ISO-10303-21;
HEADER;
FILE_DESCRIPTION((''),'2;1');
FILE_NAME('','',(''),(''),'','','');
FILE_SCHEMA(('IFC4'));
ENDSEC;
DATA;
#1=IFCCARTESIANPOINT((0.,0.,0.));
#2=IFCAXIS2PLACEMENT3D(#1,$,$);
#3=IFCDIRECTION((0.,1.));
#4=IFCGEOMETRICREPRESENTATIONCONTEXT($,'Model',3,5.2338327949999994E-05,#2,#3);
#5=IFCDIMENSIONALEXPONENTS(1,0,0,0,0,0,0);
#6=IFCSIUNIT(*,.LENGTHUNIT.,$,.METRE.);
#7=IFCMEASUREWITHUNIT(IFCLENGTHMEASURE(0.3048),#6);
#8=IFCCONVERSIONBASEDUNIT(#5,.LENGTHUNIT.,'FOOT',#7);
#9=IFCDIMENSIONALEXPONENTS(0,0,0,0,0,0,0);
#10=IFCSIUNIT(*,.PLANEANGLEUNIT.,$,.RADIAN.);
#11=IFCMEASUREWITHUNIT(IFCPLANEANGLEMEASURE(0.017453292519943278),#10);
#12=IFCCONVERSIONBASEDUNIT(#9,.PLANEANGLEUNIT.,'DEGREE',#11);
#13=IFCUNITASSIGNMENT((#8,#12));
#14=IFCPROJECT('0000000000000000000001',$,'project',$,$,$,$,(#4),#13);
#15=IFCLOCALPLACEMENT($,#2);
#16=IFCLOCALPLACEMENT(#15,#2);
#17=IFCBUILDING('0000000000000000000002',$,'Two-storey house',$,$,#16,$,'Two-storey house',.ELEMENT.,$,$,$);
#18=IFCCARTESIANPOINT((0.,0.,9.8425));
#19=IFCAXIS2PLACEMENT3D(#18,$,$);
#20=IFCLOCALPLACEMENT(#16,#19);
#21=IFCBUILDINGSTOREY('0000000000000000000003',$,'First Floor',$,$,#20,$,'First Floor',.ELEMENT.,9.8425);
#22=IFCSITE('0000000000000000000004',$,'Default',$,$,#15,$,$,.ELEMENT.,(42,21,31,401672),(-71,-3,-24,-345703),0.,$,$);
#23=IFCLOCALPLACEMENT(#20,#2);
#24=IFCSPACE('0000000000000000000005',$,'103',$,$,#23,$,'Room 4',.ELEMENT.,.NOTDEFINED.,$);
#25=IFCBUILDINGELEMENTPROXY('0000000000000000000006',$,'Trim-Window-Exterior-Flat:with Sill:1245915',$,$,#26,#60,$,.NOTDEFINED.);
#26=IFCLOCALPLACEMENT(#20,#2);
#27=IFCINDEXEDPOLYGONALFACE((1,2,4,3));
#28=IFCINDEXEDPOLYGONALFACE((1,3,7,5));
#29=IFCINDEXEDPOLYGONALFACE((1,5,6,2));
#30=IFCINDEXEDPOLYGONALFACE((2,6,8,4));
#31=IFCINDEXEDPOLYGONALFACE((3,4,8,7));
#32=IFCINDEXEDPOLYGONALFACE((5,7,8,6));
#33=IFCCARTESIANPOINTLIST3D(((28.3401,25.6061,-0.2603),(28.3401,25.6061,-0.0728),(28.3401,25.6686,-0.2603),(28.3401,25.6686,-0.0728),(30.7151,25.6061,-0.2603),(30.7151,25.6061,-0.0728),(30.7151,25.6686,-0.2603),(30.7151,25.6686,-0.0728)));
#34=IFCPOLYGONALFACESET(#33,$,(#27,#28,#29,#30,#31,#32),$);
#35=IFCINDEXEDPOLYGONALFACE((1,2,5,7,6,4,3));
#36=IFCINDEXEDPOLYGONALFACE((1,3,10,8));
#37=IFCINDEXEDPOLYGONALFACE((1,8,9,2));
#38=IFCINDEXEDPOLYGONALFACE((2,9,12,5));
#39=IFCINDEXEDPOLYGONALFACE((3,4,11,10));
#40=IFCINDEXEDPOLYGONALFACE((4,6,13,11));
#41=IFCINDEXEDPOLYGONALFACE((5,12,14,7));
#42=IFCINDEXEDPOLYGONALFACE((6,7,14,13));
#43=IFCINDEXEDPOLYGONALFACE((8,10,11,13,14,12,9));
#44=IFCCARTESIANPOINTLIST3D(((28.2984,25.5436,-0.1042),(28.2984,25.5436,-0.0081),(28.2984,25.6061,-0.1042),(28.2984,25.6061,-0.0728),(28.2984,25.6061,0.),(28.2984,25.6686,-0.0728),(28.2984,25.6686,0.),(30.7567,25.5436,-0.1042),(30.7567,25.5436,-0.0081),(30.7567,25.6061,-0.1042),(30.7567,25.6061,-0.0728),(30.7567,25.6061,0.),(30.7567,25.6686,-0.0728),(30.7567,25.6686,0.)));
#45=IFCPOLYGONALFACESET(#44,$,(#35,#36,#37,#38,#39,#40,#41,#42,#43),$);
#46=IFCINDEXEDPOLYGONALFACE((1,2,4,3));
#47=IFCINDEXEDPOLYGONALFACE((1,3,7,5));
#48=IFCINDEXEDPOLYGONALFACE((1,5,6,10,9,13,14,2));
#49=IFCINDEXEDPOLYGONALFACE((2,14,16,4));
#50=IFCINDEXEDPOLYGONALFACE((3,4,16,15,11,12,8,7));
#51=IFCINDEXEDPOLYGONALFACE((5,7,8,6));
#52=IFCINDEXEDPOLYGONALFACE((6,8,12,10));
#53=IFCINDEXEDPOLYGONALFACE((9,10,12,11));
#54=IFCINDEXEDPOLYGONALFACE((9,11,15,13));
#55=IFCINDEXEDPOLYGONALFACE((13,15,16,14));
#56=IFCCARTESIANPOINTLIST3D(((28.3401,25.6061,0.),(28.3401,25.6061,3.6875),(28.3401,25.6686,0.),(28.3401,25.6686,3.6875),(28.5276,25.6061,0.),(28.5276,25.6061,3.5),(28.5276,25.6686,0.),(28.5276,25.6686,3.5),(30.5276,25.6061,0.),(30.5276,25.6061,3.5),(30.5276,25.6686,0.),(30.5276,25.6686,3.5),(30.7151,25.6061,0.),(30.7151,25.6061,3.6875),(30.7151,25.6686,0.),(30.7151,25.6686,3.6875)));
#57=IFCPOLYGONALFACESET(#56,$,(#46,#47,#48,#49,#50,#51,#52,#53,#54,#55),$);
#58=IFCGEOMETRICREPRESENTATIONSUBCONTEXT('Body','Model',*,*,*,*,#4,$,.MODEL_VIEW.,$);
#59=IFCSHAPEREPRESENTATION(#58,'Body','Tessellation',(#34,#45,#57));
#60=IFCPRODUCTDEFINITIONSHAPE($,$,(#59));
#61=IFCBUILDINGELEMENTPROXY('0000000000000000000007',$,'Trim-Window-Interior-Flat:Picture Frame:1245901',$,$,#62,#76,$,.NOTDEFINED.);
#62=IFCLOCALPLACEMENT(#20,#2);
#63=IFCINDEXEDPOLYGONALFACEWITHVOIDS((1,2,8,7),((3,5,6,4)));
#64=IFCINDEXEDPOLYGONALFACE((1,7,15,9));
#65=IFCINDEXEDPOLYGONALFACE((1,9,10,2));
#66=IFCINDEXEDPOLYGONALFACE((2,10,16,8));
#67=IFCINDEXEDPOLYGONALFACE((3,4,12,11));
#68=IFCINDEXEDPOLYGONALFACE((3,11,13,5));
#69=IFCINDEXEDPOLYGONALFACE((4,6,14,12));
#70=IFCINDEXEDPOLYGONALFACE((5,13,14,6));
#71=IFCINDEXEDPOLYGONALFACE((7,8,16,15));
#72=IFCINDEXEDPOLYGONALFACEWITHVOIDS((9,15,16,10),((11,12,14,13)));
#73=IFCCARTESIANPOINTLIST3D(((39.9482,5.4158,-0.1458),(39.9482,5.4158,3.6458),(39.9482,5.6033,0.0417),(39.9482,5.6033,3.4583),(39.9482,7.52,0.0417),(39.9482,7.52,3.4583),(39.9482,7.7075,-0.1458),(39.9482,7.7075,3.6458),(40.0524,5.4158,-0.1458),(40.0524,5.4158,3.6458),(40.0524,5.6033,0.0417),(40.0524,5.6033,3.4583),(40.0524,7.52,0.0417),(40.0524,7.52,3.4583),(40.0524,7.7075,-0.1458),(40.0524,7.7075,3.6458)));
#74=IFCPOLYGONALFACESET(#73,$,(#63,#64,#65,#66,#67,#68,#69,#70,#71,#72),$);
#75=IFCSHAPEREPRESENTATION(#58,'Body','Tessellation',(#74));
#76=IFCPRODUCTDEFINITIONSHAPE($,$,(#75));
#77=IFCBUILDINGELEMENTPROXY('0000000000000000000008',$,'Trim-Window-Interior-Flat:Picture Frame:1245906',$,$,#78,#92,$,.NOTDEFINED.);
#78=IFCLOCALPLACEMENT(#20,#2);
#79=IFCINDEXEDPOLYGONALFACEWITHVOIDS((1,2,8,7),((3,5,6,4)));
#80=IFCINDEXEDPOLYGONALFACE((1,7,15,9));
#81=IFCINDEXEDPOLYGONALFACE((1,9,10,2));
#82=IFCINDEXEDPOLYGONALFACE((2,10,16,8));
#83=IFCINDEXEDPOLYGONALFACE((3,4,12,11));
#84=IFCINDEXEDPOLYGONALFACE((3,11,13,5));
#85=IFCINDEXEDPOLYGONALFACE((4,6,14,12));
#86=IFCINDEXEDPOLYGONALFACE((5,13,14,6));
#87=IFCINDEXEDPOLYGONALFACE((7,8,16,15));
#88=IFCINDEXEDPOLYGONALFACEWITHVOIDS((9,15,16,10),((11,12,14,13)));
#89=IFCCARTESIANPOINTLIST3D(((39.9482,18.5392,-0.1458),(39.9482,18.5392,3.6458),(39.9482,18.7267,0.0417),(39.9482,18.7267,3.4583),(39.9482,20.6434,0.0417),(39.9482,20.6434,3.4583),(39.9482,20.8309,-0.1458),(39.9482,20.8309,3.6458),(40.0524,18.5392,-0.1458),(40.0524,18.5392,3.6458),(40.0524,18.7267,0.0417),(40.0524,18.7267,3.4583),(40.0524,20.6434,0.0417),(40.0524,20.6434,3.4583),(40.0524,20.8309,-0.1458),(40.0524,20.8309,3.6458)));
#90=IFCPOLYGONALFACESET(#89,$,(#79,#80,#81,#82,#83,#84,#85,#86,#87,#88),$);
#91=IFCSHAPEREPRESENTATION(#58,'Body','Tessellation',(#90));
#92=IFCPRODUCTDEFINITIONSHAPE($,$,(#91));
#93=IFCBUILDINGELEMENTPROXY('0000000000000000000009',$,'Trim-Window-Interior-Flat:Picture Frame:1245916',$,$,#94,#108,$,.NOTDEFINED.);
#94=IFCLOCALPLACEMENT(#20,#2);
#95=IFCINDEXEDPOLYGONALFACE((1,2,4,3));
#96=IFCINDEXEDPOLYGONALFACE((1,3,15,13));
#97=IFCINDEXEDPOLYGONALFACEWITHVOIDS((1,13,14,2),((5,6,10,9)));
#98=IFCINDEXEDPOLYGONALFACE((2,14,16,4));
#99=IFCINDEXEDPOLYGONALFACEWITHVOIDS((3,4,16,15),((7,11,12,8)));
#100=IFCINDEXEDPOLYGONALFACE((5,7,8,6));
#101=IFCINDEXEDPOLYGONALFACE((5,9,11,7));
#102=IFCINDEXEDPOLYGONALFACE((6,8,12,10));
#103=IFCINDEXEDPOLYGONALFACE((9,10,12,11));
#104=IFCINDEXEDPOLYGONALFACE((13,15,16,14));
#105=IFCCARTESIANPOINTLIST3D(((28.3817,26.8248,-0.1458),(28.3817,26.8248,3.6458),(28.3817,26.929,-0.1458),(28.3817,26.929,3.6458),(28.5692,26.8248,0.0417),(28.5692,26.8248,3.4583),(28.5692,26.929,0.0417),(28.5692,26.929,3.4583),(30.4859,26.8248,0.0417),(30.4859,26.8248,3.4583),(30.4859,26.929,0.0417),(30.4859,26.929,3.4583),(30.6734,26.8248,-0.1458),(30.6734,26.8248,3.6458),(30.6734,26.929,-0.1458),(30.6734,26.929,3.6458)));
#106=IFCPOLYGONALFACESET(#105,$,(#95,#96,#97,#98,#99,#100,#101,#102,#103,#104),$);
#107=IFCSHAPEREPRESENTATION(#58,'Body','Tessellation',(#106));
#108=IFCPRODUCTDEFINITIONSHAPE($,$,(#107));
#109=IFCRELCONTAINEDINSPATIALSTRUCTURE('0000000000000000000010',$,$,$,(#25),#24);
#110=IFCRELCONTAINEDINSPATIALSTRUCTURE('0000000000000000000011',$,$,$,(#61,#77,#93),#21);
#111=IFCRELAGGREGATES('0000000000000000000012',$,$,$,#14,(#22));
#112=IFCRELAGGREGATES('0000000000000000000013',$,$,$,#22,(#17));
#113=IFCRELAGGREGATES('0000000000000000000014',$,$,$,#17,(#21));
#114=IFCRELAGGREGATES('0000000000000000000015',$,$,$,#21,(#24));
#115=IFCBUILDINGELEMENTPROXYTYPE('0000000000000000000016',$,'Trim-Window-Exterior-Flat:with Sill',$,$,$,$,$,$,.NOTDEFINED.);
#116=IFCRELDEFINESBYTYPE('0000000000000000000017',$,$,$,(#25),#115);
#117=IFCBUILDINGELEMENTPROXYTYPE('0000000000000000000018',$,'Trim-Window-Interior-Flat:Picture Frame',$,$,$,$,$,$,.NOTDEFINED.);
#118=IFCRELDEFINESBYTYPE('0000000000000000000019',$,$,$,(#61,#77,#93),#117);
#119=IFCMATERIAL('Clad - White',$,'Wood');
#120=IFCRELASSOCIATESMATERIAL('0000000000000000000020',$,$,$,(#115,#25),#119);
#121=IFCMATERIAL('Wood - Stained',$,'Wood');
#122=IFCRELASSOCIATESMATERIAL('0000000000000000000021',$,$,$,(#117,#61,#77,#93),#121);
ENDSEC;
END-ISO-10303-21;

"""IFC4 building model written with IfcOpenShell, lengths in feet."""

from ifc_helpers import new_model, entity, si_unit, converted_unit, direction, frame, origin, place, context, subcontext, project, spatial, indexed_curve, outline, extrude, source, transform, mapped, material, type_object, type_shapes, element, save


model = new_model("IFC4")

# Units and contexts
model_context = context("Model", 3, precision=5.2338327949999994e-05, world=origin(), true_north=direction((0.0, 1.0)))
body_context = subcontext(model_context, "Body", "Model", "MODEL_VIEW")
ifc_project = project(units=[converted_unit("LENGTHUNIT", "FOOT", entity("IfcLengthMeasure", 0.3048), si_unit("LENGTHUNIT", "METRE"), dimensions=[1, 0, 0, 0, 0, 0, 0]), converted_unit("PLANEANGLEUNIT", "DEGREE", entity("IfcPlaneAngleMeasure", 0.017453292519943278), si_unit("PLANEANGLEUNIT", "RADIAN"), dimensions=[0, 0, 0, 0, 0, 0, 0])], contexts=[model_context])

# Site, building, storey
site_placement = place(None, origin())
site = spatial("IfcSite", under=ifc_project, at=site_placement, Name="Default", CompositionType="ELEMENT", RefLatitude=(42, 21, 31, 401672), RefLongitude=(-71, -3, -24, -345703), RefElevation=0.0)
building_placement = place(site_placement, origin())
building = spatial("IfcBuilding", under=site, at=building_placement, Name="Two-storey house", LongName="Two-storey house", CompositionType="ELEMENT")
storey_placement = place(building_placement, frame((0.0, 0.0, 9.8425)))
storey = spatial("IfcBuildingStorey", under=building, at=storey_placement, Name="First Floor", LongName="First Floor", CompositionType="ELEMENT", Elevation=9.8425)

# Shared definitions
ifc_material_1 = material(Name="Wood - Stained", Category="Wood")

# Shared definitions
ifc_material_2 = material(Name="Clad - White", Category="Wood")

# Shared definitions
space_placement = place(storey_placement, origin())
space = spatial("IfcSpace", under=storey, at=space_placement, Name="103", LongName="Room 4", CompositionType="ELEMENT", PredefinedType="NOTDEFINED")

# Building element proxies
building_element_proxy_type_1 = type_object("IfcBuildingElementProxyType", Name="Trim-Window-Exterior-Flat:with Sill", PredefinedType="NOTDEFINED", material=ifc_material_2)
shared_shape_1 = source(origin(), body_context, "Body", "SweptSolid", [
    extrude(outline(indexed_curve([(-1.1875, -0.0938), (1.1875, -0.0938), (1.1875, 0.0938), (-1.1875, 0.0938), (-1.1875, -0.0938)], self_intersect=False)), frame((0.0, -3.6665, 0.0), z_axis=(0.0, 0.0, 1.0), x_axis=(-1.0, 0.0, 0.0)), (0.0, 0.0, 1.0), 0.0625),
    extrude(outline(indexed_curve([(-0.0625, -0.0525), (0.0, -0.0525), (0.0, -0.0211), (0.0625, -0.0211), (0.0625, 0.0517), (0.0, 0.0517), (-0.0625, 0.0436), (-0.0625, -0.0525)], self_intersect=False)), frame((-1.2292, -3.5517, 0.0625), z_axis=(1.0, 0.0, 0.0), x_axis=(0.0, 0.0, -1.0)), (0.0, 0.0, 1.0), 2.4583),
    extrude(outline(indexed_curve([(-1.8906, -1.1875), (1.7969, -1.1875), (1.7969, -1.0), (-1.7031, -1.0), (-1.7031, 1.0), (1.7969, 1.0), (1.7969, 1.1875), (-1.8906, 1.1875), (-1.8906, -1.1875)], self_intersect=False)), frame((0.0, -1.7031, 0.0), z_axis=(0.0, 0.0, 1.0), x_axis=(0.0, -1.0, 0.0)), (0.0, 0.0, 1.0), 0.0625),
])
type_shapes(building_element_proxy_type_1, [shared_shape_1])
for number, where, z_axis, x_axis, name in (
    (1, (29.5276, 25.6686, 3.5), (0.0, -1.0, 0.0), (1.0, 0.0, 0.0), "Trim-Window-Exterior-Flat:with Sill:1245915"),
):
    element("IfcBuildingElementProxy", number, at=place(space_placement, frame(where, z_axis=z_axis, x_axis=x_axis)), inside=space, type_object=building_element_proxy_type_1, material=ifc_material_2, Name=name, PredefinedType="NOTDEFINED", context=body_context, shape_type="MappedRepresentation", body=[
        mapped(shared_shape_1, transform((0.0, 0.0, 0.0), scale=1.0)),
    ])
building_element_proxy_type_2 = type_object("IfcBuildingElementProxyType", Name="Trim-Window-Interior-Flat:Picture Frame", PredefinedType="NOTDEFINED", material=ifc_material_1)
shared_shape_2 = source(origin(), body_context, "Body", "SweptSolid", [
    extrude(outline(indexed_curve([(-1.1458, -1.8958), (1.1458, -1.8958), (1.1458, 1.8958), (-1.1458, 1.8958), (-1.1458, -1.8958)], self_intersect=False), holes=[indexed_curve([(-0.9583, -1.7083), (-0.9583, 1.7083), (0.9583, 1.7083), (0.9583, -1.7083), (-0.9583, -1.7083)], self_intersect=False)]), frame((0.0, -1.75, 0.0), z_axis=(0.0, 0.0, 1.0), x_axis=(-1.0, 0.0, 0.0)), (0.0, 0.0, 1.0), 0.1042),
])
type_shapes(building_element_proxy_type_2, [shared_shape_2])
for number, where, z_axis, x_axis, name in (
    (2, (39.9482, 6.5617, 3.5), (1.0, 0.0, 0.0), (0.0, 1.0, 0.0), "Trim-Window-Interior-Flat:Picture Frame:1245901"),
    (3, (39.9482, 19.685, 3.5), (1.0, 0.0, 0.0), (0.0, 1.0, 0.0), "Trim-Window-Interior-Flat:Picture Frame:1245906"),
    (4, (29.5276, 26.8248, 3.5), (0.0, 1.0, 0.0), (-1.0, 0.0, 0.0), "Trim-Window-Interior-Flat:Picture Frame:1245916"),
):
    element("IfcBuildingElementProxy", number, at=place(storey_placement, frame(where, z_axis=z_axis, x_axis=x_axis)), inside=storey, type_object=building_element_proxy_type_2, material=ifc_material_1, Name=name, PredefinedType="NOTDEFINED", context=body_context, shape_type="MappedRepresentation", body=[
        mapped(shared_shape_2, transform((0.0, 0.0, 0.0), scale=1.0)),
    ])

save(model, "model.ifc")
